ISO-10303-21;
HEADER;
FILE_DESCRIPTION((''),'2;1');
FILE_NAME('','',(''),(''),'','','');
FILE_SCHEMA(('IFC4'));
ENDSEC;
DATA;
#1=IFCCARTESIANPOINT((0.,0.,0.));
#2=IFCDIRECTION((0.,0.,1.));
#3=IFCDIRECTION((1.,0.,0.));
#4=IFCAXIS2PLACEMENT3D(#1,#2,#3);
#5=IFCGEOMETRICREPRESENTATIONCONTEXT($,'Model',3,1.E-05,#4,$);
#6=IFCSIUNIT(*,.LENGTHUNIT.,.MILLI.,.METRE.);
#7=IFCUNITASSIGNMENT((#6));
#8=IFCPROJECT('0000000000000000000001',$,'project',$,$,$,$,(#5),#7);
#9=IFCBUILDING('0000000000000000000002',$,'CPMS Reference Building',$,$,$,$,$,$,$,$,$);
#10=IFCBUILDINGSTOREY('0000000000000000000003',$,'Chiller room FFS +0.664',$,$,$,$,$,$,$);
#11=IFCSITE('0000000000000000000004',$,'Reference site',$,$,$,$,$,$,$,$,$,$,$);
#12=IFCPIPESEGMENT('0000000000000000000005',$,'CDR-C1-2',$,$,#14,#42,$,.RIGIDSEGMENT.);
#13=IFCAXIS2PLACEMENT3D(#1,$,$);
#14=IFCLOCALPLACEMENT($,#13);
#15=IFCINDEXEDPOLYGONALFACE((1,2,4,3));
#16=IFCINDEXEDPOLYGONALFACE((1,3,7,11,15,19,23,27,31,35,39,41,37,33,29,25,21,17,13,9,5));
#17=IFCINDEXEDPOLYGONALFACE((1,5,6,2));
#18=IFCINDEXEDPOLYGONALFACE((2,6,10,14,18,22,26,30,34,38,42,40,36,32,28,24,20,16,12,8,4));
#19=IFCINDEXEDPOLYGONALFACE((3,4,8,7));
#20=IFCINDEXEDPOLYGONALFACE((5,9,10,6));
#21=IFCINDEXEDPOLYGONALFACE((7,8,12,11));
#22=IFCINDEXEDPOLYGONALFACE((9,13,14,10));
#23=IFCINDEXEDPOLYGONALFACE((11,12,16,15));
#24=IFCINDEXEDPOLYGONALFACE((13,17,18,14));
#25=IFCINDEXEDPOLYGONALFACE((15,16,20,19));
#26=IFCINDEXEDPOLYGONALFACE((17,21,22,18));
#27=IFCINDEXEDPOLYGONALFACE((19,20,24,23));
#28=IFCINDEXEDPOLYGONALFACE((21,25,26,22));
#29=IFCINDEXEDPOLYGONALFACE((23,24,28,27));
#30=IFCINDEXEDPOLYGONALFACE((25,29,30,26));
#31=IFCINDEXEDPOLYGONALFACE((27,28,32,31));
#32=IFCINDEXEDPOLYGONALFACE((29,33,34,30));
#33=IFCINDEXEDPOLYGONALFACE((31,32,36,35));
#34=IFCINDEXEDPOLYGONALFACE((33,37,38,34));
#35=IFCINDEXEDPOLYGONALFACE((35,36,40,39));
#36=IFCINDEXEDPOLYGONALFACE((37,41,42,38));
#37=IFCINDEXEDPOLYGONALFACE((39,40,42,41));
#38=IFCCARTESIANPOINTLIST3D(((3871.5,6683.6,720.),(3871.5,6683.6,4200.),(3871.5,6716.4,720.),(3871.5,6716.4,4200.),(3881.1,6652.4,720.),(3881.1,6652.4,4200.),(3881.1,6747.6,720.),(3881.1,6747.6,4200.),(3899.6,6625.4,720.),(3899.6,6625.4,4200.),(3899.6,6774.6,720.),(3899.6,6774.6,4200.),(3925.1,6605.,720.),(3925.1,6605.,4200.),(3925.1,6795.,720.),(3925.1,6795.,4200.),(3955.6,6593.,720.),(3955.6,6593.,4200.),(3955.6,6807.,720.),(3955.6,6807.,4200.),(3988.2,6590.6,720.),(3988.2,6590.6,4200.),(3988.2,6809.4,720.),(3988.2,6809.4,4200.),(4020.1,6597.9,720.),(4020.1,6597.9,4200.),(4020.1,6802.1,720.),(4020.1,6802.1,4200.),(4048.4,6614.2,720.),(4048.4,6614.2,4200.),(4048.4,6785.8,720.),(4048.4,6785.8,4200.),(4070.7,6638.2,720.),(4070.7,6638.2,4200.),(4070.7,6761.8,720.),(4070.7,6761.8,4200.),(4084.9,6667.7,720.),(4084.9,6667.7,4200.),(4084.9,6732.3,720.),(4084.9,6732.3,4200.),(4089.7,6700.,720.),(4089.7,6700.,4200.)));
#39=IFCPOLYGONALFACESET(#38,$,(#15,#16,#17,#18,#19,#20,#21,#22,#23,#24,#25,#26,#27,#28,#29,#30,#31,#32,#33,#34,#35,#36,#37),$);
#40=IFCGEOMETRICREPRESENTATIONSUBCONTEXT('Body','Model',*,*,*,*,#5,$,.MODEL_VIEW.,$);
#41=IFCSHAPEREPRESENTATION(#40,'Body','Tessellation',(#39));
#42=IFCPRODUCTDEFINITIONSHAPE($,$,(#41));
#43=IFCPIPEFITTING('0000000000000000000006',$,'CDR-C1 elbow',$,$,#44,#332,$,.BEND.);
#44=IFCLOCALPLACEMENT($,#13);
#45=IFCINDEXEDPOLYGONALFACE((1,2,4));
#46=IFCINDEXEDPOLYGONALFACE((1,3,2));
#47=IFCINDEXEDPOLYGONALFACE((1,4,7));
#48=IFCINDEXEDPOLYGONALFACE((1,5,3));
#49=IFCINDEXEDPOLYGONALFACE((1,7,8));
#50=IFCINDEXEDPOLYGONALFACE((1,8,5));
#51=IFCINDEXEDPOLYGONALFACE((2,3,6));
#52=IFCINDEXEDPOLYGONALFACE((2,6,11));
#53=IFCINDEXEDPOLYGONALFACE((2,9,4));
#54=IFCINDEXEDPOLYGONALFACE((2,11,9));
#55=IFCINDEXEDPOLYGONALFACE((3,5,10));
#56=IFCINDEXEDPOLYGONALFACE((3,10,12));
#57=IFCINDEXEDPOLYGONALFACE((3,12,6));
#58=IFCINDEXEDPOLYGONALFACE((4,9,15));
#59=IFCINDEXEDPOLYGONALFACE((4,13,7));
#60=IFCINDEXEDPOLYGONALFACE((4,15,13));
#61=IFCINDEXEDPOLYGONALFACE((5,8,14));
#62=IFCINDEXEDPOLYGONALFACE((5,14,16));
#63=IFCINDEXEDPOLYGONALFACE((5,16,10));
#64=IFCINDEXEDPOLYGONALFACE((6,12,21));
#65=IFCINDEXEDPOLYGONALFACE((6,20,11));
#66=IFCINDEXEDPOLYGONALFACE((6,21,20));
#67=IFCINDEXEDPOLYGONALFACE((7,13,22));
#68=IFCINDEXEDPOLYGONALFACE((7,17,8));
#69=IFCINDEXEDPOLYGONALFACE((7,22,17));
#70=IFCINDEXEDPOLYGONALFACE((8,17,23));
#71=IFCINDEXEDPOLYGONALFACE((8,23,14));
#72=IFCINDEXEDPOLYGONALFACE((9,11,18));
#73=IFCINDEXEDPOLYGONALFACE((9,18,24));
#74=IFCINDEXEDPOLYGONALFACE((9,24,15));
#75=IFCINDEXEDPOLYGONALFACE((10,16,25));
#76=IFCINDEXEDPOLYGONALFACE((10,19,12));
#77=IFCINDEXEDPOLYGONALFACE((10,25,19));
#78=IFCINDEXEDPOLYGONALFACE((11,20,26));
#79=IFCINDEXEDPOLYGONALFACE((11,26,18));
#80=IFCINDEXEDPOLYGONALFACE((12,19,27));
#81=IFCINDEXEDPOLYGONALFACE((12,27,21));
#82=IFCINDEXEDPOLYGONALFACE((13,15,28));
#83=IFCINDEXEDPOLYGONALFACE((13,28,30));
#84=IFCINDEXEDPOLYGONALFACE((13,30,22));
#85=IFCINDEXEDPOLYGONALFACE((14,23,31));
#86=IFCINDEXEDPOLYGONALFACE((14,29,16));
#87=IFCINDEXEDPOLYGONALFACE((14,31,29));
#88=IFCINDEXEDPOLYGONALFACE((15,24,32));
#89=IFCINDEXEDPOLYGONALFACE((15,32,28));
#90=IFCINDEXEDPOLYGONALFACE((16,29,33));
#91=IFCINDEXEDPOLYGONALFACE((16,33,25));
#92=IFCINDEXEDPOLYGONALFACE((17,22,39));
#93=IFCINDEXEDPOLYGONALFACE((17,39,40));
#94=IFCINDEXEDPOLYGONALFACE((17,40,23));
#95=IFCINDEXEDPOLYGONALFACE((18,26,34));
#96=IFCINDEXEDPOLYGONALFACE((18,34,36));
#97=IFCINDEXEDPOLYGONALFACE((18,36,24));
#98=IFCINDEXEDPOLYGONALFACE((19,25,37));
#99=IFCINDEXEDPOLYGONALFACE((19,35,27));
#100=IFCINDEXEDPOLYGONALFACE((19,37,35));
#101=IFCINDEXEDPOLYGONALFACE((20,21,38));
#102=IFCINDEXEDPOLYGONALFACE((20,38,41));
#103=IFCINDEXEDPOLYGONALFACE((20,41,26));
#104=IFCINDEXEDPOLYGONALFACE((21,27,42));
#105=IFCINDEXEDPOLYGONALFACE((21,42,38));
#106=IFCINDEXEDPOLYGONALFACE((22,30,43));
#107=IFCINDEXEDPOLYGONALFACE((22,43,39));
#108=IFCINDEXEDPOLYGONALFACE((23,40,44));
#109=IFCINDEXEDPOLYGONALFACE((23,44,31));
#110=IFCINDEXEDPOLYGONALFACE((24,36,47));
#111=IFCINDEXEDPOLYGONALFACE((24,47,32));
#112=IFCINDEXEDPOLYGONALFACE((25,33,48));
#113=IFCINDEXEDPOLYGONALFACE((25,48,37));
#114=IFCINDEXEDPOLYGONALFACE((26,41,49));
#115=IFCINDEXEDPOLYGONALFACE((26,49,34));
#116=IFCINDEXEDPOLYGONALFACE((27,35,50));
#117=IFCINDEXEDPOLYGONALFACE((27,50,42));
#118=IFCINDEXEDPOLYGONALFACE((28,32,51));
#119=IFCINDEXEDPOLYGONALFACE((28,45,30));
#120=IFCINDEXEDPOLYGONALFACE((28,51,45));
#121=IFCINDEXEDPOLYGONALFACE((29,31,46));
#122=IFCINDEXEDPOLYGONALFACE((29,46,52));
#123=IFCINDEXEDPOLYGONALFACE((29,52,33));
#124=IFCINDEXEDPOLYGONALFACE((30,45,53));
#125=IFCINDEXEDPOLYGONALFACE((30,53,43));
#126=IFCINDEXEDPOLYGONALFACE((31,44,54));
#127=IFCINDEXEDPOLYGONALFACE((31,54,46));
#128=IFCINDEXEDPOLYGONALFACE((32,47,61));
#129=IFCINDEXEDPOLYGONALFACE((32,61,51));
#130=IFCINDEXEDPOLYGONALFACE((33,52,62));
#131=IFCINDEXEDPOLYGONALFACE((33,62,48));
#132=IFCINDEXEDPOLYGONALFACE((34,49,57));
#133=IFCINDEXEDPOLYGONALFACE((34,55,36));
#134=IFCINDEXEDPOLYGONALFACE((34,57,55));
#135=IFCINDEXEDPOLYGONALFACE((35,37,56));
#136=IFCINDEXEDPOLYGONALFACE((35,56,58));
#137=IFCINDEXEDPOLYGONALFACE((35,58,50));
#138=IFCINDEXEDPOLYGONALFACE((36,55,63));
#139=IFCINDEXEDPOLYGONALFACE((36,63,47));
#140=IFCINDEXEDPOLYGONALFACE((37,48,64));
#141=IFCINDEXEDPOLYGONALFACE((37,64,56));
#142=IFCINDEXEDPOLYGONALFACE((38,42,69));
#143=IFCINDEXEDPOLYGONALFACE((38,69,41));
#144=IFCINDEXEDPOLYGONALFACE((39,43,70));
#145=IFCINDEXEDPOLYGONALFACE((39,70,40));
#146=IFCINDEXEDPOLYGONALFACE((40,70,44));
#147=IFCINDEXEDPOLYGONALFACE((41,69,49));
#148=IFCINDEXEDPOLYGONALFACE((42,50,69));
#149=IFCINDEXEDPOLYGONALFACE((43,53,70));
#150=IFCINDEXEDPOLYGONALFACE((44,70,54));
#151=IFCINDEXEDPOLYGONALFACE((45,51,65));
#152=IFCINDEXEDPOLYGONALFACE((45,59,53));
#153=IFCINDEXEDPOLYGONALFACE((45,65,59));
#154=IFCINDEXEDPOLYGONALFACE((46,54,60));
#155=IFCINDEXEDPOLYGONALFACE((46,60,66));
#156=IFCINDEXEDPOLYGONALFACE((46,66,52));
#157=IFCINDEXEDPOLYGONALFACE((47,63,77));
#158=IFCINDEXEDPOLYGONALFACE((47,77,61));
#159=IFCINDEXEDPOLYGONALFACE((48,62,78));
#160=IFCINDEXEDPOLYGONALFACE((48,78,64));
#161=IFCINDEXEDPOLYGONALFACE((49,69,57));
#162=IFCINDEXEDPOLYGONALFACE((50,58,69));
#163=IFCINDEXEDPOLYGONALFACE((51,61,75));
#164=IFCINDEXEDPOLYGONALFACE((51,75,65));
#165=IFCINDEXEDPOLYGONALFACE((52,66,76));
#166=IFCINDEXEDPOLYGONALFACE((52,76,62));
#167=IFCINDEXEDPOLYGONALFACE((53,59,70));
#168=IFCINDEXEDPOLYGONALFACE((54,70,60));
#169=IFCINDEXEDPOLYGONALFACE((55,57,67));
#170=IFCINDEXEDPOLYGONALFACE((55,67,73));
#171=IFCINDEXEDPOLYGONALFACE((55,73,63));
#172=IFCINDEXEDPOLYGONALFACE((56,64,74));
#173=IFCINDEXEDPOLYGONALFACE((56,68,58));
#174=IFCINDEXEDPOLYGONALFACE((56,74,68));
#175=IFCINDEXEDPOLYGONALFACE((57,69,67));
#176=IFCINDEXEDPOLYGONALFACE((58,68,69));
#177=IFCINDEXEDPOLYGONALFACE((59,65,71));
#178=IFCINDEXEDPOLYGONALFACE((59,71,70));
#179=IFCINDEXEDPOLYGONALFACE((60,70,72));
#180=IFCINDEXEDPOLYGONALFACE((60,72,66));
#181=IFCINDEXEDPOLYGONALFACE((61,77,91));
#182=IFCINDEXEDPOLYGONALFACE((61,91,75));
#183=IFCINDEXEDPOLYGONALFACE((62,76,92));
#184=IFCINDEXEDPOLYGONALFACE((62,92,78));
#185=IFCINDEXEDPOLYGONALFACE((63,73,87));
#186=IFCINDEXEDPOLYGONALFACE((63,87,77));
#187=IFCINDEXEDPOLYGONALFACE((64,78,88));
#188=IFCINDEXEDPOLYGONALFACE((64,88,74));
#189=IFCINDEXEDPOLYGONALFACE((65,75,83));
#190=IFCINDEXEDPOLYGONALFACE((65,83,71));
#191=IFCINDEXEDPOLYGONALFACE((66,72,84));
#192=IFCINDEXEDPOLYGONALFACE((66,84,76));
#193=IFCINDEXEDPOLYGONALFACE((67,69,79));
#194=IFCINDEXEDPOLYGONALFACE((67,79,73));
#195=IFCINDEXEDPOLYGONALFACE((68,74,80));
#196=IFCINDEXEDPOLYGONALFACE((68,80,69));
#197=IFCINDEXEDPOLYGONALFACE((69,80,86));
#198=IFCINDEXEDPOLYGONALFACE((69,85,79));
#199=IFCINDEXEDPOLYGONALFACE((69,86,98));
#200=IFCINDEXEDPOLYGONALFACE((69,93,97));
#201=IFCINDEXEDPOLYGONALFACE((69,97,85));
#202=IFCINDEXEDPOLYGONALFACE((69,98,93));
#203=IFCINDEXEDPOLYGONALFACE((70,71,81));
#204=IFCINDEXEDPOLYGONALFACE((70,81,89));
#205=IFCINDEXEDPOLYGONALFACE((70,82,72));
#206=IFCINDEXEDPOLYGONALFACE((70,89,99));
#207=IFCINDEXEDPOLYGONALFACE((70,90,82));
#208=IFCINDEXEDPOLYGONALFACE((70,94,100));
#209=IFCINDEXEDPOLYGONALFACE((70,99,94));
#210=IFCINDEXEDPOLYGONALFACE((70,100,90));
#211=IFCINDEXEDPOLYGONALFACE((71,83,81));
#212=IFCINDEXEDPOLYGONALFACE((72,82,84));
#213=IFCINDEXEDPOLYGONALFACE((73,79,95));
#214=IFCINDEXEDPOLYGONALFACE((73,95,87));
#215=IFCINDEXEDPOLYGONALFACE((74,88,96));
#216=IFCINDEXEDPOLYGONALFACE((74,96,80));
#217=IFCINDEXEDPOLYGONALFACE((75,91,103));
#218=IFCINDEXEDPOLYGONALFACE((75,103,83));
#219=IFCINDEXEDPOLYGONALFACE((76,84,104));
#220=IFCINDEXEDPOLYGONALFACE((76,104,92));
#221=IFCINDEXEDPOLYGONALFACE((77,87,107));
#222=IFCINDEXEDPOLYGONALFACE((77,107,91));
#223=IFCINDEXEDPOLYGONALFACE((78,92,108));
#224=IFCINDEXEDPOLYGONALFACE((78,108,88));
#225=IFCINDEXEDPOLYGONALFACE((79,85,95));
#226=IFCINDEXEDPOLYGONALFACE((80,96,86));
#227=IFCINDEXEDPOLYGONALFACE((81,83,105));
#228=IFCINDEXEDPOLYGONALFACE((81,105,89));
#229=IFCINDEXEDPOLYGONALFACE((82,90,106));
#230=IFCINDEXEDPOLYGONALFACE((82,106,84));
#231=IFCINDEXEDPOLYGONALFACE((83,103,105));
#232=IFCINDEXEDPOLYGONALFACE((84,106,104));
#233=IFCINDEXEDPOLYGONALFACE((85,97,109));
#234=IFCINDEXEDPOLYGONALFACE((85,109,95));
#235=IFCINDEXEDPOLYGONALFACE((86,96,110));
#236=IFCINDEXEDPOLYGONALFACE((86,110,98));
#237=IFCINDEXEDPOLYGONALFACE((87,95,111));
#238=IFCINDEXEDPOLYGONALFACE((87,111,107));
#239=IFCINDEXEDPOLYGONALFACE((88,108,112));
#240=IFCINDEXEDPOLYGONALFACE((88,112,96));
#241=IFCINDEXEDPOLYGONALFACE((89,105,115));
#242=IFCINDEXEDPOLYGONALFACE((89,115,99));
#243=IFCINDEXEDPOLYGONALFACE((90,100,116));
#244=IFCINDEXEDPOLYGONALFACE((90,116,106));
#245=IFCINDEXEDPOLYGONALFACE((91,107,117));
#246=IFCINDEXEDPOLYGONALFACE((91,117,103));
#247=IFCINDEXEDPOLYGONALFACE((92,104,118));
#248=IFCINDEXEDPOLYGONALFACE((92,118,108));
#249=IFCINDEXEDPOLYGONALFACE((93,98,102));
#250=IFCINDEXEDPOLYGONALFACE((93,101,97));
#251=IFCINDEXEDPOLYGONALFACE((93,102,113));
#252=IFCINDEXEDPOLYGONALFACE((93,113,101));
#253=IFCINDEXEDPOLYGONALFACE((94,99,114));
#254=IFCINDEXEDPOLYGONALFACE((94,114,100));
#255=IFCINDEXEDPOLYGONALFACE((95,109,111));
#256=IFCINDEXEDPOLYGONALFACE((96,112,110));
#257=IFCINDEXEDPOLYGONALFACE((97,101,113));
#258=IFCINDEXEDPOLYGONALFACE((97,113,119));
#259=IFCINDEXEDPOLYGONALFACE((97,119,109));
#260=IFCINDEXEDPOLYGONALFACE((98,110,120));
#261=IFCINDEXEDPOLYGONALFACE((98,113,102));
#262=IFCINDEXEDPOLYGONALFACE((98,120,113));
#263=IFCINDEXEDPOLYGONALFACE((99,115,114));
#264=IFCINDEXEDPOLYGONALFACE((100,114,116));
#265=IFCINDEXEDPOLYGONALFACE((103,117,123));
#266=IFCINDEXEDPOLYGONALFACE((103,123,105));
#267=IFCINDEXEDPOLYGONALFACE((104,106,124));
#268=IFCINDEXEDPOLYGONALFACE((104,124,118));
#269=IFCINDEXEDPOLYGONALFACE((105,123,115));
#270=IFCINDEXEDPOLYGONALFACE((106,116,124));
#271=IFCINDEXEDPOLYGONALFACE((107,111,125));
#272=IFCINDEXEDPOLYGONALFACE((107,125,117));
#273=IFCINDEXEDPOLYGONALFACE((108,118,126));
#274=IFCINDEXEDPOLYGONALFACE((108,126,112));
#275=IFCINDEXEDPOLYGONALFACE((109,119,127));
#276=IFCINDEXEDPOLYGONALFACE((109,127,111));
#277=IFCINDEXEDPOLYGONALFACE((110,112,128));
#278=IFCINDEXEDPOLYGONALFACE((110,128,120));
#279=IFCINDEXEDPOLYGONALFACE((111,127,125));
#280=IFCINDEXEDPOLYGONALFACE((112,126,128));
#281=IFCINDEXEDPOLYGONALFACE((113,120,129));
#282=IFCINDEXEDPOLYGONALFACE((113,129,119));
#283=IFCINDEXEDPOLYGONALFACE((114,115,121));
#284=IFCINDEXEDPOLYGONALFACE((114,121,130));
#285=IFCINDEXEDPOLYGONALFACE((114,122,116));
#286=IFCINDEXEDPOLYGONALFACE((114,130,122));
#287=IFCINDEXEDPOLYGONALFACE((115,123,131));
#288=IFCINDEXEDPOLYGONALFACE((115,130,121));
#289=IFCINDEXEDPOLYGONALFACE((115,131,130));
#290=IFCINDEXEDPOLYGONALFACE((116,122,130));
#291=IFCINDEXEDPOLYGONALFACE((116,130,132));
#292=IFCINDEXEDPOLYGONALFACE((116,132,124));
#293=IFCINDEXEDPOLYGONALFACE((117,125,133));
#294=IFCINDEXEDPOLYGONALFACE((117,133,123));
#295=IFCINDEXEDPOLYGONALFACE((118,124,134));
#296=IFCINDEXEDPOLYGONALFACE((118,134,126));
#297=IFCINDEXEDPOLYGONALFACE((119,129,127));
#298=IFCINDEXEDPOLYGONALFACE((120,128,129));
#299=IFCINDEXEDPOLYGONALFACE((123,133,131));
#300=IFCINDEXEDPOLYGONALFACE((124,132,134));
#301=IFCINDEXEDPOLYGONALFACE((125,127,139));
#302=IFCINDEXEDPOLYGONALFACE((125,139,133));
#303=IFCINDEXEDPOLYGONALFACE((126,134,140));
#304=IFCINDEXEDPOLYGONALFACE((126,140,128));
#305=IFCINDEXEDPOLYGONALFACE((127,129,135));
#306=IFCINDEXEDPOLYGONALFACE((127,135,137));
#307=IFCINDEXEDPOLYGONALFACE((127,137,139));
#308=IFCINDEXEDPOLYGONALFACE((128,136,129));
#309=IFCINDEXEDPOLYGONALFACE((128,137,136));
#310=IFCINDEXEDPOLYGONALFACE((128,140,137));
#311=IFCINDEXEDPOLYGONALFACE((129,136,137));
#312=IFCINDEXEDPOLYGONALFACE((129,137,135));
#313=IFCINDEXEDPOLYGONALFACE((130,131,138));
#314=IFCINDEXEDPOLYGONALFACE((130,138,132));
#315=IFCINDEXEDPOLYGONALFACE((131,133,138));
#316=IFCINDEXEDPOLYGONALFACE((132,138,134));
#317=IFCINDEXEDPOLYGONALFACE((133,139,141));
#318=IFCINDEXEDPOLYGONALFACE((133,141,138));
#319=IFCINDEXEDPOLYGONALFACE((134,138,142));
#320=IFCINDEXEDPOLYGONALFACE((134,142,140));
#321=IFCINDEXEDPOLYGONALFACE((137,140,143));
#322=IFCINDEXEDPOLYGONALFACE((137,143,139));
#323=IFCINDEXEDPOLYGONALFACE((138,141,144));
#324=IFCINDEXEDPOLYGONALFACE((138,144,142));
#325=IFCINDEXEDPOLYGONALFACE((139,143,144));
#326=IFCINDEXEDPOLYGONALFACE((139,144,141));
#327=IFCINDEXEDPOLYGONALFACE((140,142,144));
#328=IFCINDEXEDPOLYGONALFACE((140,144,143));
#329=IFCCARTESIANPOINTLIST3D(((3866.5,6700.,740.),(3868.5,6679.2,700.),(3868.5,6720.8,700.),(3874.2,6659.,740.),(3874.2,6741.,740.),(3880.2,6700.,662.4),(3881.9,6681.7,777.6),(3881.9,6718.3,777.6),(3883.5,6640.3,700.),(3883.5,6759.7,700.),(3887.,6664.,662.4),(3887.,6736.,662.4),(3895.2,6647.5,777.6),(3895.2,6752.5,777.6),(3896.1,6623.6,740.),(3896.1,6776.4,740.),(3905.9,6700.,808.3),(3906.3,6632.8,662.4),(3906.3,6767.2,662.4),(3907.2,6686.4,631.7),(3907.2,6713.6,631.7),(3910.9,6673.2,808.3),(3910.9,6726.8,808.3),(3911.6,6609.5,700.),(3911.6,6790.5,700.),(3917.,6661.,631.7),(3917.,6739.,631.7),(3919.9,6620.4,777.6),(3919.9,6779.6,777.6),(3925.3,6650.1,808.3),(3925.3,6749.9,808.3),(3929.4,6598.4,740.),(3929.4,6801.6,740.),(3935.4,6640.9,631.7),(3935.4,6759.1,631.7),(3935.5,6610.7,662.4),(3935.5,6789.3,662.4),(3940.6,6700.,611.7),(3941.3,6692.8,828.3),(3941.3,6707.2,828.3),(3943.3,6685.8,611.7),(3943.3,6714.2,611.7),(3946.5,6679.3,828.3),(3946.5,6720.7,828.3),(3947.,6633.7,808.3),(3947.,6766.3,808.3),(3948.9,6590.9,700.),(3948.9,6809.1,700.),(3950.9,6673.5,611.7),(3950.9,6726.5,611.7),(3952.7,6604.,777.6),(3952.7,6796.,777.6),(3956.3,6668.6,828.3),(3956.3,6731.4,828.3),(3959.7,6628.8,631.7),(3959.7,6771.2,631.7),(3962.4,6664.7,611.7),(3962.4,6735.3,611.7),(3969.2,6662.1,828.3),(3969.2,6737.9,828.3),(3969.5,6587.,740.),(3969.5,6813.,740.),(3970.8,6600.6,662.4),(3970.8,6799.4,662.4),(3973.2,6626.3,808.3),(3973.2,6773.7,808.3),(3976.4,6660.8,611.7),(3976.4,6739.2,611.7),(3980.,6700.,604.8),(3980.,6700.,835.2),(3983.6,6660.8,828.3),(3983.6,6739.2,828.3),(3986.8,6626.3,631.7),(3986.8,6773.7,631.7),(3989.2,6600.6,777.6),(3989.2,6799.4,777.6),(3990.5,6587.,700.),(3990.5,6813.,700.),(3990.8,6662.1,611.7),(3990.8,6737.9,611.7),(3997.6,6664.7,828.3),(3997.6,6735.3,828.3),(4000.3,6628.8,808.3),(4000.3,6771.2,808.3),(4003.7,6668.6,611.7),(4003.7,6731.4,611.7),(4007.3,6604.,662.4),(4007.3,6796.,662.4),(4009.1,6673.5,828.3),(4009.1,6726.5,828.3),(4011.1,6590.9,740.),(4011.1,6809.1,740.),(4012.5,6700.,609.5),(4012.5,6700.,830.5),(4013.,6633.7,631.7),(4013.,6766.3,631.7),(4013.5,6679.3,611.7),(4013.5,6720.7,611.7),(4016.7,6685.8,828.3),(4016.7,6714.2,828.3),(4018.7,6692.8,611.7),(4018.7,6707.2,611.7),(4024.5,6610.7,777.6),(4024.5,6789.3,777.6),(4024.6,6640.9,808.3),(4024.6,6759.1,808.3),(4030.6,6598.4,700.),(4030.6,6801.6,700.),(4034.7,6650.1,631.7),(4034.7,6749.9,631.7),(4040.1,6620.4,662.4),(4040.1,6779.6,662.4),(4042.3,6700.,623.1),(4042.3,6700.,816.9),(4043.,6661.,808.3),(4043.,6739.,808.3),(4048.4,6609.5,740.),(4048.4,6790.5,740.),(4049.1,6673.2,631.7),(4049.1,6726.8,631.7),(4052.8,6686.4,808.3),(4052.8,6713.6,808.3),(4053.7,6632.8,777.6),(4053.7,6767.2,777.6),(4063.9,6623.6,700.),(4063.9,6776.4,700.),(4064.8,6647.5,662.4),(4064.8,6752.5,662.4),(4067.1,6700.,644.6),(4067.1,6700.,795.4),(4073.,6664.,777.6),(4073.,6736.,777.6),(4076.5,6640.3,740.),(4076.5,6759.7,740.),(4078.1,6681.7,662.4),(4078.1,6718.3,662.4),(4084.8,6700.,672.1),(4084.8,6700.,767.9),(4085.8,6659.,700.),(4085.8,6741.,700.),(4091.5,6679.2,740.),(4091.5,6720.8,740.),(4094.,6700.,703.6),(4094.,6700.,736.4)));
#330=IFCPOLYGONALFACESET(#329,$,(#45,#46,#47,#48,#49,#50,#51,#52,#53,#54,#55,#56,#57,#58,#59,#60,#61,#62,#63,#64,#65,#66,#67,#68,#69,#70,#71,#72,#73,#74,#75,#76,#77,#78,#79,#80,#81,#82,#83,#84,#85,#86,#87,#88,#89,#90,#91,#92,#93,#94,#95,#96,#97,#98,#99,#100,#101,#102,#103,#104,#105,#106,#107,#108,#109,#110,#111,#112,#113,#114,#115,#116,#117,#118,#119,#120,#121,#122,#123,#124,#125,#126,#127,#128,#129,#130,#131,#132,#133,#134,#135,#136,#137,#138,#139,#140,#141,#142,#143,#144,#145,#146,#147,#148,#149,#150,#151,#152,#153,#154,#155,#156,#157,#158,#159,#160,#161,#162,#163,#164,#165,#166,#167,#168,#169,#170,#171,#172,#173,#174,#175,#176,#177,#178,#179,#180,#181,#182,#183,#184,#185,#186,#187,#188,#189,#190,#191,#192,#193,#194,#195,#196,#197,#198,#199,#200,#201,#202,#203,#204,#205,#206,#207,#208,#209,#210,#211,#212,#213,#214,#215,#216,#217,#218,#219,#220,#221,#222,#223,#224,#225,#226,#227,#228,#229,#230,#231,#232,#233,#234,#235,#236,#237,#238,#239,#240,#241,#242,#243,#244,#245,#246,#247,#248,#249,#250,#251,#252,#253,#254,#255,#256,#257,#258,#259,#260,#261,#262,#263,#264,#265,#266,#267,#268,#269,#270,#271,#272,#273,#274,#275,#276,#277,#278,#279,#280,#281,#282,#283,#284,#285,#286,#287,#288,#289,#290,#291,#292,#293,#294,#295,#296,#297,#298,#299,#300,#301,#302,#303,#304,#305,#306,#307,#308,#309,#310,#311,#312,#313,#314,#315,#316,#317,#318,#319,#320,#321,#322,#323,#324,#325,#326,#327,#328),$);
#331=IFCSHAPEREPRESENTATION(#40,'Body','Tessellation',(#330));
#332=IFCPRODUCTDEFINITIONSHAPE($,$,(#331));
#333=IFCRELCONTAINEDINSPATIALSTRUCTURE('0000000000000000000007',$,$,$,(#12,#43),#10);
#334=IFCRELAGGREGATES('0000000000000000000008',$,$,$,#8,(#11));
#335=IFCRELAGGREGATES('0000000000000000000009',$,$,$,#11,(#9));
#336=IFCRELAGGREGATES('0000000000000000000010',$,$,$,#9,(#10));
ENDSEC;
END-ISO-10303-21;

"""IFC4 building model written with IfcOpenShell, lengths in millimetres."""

from ifc_helpers import new_model, entity, si_unit, frame, origin_with_axes, origin_2d, place, context, subcontext, project, spatial, circle_curve, outline, extrude, element, save


model = new_model("IFC4")

# Units and contexts
model_context = context("Model", 3, precision=1e-05, world=origin_with_axes())
body_context = subcontext(model_context, "Body", "Model", "MODEL_VIEW")
ifc_project = project(units=[si_unit("LENGTHUNIT", "METRE", prefix="MILLI")], contexts=[model_context])

# Site, building, storey
site = spatial("IfcSite", under=ifc_project, Name="Reference site")
building = spatial("IfcBuilding", under=site, Name="CPMS Reference Building")
storey = spatial("IfcBuildingStorey", under=building, Name="Chiller room FFS +0.664")

# Pipe segment
pipe_segment_1_placement = place(None, origin_with_axes())
element("IfcPipeSegment", 1, at=pipe_segment_1_placement, inside=storey, Name="CDR-C1-2", PredefinedType="RIGIDSEGMENT", context=body_context, shape_type="SweptSolid", body=[
    extrude(outline(circle_curve(origin_2d(), 109.7)), frame((3980.0, 6700.0, 720.0), z_axis=(0.0, 0.0, 1.0), x_axis=(1.0, 0.0, 0.0)), (0.0, 0.0, 1.0), 3480.0),
])

# Pipe fitting
pipe_fitting_1_placement = place(None, origin_with_axes())
element("IfcPipeFitting", 2, at=pipe_fitting_1_placement, inside=storey, Name="CDR-C1 elbow", PredefinedType="BEND", context=body_context, shape_type="CSG", body=[
    entity("IfcSphere", entity("IfcAxis2Placement3D", entity("IfcCartesianPoint", [3980.0, 6700.0, 720.0]), entity("IfcDirection", [0.0, 0.0, 1.0]), entity("IfcDirection", [1.0, 0.0, 0.0])), 115.2),
])

save(model, "model.ifc")
